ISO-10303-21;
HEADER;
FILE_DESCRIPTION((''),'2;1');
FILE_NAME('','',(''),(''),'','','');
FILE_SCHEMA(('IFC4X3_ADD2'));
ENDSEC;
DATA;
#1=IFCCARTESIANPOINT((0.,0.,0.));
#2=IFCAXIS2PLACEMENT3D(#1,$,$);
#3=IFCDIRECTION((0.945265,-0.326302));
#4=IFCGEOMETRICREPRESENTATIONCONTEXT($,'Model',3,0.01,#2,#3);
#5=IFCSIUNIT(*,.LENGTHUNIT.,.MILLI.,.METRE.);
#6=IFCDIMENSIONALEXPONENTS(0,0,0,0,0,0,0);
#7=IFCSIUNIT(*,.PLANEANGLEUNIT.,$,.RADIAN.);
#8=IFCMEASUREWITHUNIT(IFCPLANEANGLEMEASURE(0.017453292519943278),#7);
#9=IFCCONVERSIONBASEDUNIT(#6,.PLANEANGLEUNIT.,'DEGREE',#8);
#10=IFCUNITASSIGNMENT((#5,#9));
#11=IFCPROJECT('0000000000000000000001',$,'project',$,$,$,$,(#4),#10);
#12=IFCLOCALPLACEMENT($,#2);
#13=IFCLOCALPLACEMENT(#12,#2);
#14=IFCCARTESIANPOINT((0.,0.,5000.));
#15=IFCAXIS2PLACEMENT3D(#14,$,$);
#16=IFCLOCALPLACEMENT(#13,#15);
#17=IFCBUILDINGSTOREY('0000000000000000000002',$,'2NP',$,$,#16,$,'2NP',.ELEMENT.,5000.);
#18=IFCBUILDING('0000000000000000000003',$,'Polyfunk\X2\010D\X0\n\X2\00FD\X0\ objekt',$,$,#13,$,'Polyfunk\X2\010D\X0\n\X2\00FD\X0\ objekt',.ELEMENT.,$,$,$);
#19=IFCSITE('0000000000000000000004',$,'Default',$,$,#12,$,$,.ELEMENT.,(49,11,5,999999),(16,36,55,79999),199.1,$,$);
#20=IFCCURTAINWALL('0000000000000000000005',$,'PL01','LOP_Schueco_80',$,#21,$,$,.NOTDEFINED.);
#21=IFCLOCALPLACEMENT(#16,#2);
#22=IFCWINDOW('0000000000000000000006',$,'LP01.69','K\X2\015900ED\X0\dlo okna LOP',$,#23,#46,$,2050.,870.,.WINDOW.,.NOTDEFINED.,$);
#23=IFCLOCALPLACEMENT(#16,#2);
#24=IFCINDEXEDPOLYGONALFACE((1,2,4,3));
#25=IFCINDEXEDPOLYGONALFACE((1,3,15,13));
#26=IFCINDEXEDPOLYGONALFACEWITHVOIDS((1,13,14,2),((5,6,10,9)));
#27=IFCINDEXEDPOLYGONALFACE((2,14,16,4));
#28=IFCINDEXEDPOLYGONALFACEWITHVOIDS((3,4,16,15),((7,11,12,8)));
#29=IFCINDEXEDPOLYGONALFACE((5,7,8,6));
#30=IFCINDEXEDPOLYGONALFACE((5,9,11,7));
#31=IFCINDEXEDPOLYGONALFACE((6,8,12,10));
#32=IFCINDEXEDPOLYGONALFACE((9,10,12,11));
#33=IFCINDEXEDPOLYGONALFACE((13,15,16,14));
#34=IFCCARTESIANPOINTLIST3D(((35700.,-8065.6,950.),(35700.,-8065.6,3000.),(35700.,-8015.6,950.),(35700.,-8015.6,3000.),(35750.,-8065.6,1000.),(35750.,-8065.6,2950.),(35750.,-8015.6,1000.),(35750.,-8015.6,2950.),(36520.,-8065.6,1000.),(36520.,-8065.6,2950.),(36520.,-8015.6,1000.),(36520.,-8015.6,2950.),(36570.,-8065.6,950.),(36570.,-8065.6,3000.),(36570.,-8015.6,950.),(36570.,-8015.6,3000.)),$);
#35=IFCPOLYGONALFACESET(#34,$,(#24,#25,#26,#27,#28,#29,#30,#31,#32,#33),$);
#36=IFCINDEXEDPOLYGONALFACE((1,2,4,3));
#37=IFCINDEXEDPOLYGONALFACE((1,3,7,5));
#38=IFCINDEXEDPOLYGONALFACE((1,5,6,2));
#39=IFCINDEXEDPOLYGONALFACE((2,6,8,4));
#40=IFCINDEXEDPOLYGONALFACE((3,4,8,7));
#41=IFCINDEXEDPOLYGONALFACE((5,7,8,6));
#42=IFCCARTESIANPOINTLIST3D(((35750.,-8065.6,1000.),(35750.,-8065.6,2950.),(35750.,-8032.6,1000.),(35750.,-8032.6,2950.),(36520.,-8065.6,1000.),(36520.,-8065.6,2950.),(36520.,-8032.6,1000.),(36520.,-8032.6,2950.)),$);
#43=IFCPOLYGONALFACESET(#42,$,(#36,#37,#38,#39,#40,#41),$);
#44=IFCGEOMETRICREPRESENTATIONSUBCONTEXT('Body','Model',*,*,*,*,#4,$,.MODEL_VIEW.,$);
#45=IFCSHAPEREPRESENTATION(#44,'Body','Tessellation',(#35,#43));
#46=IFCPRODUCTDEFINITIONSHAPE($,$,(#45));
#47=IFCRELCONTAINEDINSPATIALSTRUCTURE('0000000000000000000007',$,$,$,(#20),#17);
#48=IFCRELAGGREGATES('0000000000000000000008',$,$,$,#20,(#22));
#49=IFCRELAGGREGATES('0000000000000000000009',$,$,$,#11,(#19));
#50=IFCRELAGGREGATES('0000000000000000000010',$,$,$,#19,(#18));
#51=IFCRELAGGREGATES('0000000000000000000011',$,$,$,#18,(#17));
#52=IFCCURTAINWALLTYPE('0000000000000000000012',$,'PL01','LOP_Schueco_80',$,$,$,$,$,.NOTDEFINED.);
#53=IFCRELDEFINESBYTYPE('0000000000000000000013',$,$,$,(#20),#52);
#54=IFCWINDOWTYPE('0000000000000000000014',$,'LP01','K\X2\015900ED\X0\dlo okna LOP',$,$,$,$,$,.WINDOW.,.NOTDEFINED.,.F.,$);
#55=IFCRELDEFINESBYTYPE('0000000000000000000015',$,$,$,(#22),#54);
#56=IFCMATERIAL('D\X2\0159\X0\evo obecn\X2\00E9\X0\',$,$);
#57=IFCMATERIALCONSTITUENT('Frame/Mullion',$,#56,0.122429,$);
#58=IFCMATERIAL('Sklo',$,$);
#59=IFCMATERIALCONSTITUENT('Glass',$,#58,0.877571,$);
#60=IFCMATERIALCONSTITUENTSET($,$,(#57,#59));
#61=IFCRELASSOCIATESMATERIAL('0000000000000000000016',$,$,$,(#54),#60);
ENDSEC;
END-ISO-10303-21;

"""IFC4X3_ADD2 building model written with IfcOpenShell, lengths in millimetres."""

from ifc_helpers import new_model, entity, si_unit, converted_unit, direction, frame, frame_2d, origin, place, context, subcontext, project, spatial, polyline, rectangle, outline, extrude, source, transform, mapped, material, constituent, constituent_set, type_object, type_shapes, element, aggregate, save


model = new_model("IFC4X3_ADD2")

# Units and contexts
model_context = context("Model", 3, precision=0.01, world=origin(), true_north=direction((0.945265, -0.326302)))
body_context = subcontext(model_context, "Body", "Model", "MODEL_VIEW")
ifc_project = project(units=[si_unit("LENGTHUNIT", "METRE", prefix="MILLI"), converted_unit("PLANEANGLEUNIT", "DEGREE", entity("IfcPlaneAngleMeasure", 0.017453292519943278), si_unit("PLANEANGLEUNIT", "RADIAN"), dimensions=[0, 0, 0, 0, 0, 0, 0])], contexts=[model_context])

# Site, building, storey
site_placement = place(None, origin())
site = spatial("IfcSite", under=ifc_project, at=site_placement, Name="Default", CompositionType="ELEMENT", RefLatitude=(49, 11, 5, 999999), RefLongitude=(16, 36, 55, 79999), RefElevation=199.1)
building_placement = place(site_placement, origin())
building = spatial("IfcBuilding", under=site, at=building_placement, Name="Polyfunkčný objekt", LongName="Polyfunkčný objekt", CompositionType="ELEMENT")
storey_placement = place(building_placement, frame((0.0, 0.0, 5000.0)))
storey = spatial("IfcBuildingStorey", under=building, at=storey_placement, Name="2NP", LongName="2NP", CompositionType="ELEMENT", Elevation=5000.0)

# Curtain wall
curtain_wall_type = type_object("IfcCurtainWallType", Name="PL01", Description="LOP_Schueco_80", PredefinedType="NOTDEFINED")
curtain_wall_placement = place(storey_placement, frame((0.0, 0.0, -5000.0)))
curtain_wall = element("IfcCurtainWall", 1, at=curtain_wall_placement, inside=storey, type_object=curtain_wall_type, Name="PL01", Description="LOP_Schueco_80", PredefinedType="NOTDEFINED")
ifc_material_1 = material(Name="Sklo")

# Window
ifc_material_2 = material(Name="Dřevo obecné")
ifc_constituent_1 = constituent(ifc_material_2, Name="Frame/Mullion", fraction=0.122429)
ifc_constituent_2 = constituent(ifc_material_1, Name="Glass", fraction=0.877571)
ifc_constituent_set = constituent_set(constituents=[ifc_constituent_1, ifc_constituent_2])
window_type = type_object("IfcWindowType", Name="LP01", Description="Křídlo okna LOP", ParameterTakesPrecedence=False, PartitioningType="NOTDEFINED", PredefinedType="WINDOW", material=ifc_constituent_set)
shared_shape_1 = source(origin(), body_context, "Body", "SweptSolid", [
    extrude(outline(polyline([(-1025.0, -435.0), (1025.0, -435.0), (1025.0, 435.0), (-1025.0, 435.0), (-1025.0, -435.0)]), holes=[polyline([(-975.0, -385.0), (-975.0, 385.0), (975.0, 385.0), (975.0, -385.0), (-975.0, -385.0)])]), frame((0.0, 50.0, 1025.0), z_axis=(0.0, -1.0, 0.0), x_axis=(0.0, 0.0, -1.0)), (0.0, 0.0, 1.0), 50.0),
    extrude(rectangle(XDim=770.0, YDim=33.0, at=frame_2d((0.0, 0.0), x_axis=(1.0, 0.0))), frame((0.0, 33.5, 50.0), z_axis=(0.0, 0.0, 1.0), x_axis=(-1.0, 0.0, 0.0)), (0.0, 0.0, 1.0), 1950.0),
])
type_shapes(window_type, [shared_shape_1])
window_placement = place(curtain_wall_placement, frame((36135.0, -8015.6, 5950.0), z_axis=(0.0, 0.0, 1.0), x_axis=(-1.0, 0.0, 0.0)))
window = element("IfcWindow", 2, at=window_placement, type_object=window_type, Name="LP01.69", Description="Křídlo okna LOP", OverallHeight=2050.0, OverallWidth=870.0, PartitioningType="NOTDEFINED", PredefinedType="WINDOW", context=body_context, shape_type="MappedRepresentation", body=[
    mapped(shared_shape_1, transform((0.0, 0.0, 0.0), scale=1.0)),
])
aggregate(curtain_wall, [window])

save(model, "model.ifc")
